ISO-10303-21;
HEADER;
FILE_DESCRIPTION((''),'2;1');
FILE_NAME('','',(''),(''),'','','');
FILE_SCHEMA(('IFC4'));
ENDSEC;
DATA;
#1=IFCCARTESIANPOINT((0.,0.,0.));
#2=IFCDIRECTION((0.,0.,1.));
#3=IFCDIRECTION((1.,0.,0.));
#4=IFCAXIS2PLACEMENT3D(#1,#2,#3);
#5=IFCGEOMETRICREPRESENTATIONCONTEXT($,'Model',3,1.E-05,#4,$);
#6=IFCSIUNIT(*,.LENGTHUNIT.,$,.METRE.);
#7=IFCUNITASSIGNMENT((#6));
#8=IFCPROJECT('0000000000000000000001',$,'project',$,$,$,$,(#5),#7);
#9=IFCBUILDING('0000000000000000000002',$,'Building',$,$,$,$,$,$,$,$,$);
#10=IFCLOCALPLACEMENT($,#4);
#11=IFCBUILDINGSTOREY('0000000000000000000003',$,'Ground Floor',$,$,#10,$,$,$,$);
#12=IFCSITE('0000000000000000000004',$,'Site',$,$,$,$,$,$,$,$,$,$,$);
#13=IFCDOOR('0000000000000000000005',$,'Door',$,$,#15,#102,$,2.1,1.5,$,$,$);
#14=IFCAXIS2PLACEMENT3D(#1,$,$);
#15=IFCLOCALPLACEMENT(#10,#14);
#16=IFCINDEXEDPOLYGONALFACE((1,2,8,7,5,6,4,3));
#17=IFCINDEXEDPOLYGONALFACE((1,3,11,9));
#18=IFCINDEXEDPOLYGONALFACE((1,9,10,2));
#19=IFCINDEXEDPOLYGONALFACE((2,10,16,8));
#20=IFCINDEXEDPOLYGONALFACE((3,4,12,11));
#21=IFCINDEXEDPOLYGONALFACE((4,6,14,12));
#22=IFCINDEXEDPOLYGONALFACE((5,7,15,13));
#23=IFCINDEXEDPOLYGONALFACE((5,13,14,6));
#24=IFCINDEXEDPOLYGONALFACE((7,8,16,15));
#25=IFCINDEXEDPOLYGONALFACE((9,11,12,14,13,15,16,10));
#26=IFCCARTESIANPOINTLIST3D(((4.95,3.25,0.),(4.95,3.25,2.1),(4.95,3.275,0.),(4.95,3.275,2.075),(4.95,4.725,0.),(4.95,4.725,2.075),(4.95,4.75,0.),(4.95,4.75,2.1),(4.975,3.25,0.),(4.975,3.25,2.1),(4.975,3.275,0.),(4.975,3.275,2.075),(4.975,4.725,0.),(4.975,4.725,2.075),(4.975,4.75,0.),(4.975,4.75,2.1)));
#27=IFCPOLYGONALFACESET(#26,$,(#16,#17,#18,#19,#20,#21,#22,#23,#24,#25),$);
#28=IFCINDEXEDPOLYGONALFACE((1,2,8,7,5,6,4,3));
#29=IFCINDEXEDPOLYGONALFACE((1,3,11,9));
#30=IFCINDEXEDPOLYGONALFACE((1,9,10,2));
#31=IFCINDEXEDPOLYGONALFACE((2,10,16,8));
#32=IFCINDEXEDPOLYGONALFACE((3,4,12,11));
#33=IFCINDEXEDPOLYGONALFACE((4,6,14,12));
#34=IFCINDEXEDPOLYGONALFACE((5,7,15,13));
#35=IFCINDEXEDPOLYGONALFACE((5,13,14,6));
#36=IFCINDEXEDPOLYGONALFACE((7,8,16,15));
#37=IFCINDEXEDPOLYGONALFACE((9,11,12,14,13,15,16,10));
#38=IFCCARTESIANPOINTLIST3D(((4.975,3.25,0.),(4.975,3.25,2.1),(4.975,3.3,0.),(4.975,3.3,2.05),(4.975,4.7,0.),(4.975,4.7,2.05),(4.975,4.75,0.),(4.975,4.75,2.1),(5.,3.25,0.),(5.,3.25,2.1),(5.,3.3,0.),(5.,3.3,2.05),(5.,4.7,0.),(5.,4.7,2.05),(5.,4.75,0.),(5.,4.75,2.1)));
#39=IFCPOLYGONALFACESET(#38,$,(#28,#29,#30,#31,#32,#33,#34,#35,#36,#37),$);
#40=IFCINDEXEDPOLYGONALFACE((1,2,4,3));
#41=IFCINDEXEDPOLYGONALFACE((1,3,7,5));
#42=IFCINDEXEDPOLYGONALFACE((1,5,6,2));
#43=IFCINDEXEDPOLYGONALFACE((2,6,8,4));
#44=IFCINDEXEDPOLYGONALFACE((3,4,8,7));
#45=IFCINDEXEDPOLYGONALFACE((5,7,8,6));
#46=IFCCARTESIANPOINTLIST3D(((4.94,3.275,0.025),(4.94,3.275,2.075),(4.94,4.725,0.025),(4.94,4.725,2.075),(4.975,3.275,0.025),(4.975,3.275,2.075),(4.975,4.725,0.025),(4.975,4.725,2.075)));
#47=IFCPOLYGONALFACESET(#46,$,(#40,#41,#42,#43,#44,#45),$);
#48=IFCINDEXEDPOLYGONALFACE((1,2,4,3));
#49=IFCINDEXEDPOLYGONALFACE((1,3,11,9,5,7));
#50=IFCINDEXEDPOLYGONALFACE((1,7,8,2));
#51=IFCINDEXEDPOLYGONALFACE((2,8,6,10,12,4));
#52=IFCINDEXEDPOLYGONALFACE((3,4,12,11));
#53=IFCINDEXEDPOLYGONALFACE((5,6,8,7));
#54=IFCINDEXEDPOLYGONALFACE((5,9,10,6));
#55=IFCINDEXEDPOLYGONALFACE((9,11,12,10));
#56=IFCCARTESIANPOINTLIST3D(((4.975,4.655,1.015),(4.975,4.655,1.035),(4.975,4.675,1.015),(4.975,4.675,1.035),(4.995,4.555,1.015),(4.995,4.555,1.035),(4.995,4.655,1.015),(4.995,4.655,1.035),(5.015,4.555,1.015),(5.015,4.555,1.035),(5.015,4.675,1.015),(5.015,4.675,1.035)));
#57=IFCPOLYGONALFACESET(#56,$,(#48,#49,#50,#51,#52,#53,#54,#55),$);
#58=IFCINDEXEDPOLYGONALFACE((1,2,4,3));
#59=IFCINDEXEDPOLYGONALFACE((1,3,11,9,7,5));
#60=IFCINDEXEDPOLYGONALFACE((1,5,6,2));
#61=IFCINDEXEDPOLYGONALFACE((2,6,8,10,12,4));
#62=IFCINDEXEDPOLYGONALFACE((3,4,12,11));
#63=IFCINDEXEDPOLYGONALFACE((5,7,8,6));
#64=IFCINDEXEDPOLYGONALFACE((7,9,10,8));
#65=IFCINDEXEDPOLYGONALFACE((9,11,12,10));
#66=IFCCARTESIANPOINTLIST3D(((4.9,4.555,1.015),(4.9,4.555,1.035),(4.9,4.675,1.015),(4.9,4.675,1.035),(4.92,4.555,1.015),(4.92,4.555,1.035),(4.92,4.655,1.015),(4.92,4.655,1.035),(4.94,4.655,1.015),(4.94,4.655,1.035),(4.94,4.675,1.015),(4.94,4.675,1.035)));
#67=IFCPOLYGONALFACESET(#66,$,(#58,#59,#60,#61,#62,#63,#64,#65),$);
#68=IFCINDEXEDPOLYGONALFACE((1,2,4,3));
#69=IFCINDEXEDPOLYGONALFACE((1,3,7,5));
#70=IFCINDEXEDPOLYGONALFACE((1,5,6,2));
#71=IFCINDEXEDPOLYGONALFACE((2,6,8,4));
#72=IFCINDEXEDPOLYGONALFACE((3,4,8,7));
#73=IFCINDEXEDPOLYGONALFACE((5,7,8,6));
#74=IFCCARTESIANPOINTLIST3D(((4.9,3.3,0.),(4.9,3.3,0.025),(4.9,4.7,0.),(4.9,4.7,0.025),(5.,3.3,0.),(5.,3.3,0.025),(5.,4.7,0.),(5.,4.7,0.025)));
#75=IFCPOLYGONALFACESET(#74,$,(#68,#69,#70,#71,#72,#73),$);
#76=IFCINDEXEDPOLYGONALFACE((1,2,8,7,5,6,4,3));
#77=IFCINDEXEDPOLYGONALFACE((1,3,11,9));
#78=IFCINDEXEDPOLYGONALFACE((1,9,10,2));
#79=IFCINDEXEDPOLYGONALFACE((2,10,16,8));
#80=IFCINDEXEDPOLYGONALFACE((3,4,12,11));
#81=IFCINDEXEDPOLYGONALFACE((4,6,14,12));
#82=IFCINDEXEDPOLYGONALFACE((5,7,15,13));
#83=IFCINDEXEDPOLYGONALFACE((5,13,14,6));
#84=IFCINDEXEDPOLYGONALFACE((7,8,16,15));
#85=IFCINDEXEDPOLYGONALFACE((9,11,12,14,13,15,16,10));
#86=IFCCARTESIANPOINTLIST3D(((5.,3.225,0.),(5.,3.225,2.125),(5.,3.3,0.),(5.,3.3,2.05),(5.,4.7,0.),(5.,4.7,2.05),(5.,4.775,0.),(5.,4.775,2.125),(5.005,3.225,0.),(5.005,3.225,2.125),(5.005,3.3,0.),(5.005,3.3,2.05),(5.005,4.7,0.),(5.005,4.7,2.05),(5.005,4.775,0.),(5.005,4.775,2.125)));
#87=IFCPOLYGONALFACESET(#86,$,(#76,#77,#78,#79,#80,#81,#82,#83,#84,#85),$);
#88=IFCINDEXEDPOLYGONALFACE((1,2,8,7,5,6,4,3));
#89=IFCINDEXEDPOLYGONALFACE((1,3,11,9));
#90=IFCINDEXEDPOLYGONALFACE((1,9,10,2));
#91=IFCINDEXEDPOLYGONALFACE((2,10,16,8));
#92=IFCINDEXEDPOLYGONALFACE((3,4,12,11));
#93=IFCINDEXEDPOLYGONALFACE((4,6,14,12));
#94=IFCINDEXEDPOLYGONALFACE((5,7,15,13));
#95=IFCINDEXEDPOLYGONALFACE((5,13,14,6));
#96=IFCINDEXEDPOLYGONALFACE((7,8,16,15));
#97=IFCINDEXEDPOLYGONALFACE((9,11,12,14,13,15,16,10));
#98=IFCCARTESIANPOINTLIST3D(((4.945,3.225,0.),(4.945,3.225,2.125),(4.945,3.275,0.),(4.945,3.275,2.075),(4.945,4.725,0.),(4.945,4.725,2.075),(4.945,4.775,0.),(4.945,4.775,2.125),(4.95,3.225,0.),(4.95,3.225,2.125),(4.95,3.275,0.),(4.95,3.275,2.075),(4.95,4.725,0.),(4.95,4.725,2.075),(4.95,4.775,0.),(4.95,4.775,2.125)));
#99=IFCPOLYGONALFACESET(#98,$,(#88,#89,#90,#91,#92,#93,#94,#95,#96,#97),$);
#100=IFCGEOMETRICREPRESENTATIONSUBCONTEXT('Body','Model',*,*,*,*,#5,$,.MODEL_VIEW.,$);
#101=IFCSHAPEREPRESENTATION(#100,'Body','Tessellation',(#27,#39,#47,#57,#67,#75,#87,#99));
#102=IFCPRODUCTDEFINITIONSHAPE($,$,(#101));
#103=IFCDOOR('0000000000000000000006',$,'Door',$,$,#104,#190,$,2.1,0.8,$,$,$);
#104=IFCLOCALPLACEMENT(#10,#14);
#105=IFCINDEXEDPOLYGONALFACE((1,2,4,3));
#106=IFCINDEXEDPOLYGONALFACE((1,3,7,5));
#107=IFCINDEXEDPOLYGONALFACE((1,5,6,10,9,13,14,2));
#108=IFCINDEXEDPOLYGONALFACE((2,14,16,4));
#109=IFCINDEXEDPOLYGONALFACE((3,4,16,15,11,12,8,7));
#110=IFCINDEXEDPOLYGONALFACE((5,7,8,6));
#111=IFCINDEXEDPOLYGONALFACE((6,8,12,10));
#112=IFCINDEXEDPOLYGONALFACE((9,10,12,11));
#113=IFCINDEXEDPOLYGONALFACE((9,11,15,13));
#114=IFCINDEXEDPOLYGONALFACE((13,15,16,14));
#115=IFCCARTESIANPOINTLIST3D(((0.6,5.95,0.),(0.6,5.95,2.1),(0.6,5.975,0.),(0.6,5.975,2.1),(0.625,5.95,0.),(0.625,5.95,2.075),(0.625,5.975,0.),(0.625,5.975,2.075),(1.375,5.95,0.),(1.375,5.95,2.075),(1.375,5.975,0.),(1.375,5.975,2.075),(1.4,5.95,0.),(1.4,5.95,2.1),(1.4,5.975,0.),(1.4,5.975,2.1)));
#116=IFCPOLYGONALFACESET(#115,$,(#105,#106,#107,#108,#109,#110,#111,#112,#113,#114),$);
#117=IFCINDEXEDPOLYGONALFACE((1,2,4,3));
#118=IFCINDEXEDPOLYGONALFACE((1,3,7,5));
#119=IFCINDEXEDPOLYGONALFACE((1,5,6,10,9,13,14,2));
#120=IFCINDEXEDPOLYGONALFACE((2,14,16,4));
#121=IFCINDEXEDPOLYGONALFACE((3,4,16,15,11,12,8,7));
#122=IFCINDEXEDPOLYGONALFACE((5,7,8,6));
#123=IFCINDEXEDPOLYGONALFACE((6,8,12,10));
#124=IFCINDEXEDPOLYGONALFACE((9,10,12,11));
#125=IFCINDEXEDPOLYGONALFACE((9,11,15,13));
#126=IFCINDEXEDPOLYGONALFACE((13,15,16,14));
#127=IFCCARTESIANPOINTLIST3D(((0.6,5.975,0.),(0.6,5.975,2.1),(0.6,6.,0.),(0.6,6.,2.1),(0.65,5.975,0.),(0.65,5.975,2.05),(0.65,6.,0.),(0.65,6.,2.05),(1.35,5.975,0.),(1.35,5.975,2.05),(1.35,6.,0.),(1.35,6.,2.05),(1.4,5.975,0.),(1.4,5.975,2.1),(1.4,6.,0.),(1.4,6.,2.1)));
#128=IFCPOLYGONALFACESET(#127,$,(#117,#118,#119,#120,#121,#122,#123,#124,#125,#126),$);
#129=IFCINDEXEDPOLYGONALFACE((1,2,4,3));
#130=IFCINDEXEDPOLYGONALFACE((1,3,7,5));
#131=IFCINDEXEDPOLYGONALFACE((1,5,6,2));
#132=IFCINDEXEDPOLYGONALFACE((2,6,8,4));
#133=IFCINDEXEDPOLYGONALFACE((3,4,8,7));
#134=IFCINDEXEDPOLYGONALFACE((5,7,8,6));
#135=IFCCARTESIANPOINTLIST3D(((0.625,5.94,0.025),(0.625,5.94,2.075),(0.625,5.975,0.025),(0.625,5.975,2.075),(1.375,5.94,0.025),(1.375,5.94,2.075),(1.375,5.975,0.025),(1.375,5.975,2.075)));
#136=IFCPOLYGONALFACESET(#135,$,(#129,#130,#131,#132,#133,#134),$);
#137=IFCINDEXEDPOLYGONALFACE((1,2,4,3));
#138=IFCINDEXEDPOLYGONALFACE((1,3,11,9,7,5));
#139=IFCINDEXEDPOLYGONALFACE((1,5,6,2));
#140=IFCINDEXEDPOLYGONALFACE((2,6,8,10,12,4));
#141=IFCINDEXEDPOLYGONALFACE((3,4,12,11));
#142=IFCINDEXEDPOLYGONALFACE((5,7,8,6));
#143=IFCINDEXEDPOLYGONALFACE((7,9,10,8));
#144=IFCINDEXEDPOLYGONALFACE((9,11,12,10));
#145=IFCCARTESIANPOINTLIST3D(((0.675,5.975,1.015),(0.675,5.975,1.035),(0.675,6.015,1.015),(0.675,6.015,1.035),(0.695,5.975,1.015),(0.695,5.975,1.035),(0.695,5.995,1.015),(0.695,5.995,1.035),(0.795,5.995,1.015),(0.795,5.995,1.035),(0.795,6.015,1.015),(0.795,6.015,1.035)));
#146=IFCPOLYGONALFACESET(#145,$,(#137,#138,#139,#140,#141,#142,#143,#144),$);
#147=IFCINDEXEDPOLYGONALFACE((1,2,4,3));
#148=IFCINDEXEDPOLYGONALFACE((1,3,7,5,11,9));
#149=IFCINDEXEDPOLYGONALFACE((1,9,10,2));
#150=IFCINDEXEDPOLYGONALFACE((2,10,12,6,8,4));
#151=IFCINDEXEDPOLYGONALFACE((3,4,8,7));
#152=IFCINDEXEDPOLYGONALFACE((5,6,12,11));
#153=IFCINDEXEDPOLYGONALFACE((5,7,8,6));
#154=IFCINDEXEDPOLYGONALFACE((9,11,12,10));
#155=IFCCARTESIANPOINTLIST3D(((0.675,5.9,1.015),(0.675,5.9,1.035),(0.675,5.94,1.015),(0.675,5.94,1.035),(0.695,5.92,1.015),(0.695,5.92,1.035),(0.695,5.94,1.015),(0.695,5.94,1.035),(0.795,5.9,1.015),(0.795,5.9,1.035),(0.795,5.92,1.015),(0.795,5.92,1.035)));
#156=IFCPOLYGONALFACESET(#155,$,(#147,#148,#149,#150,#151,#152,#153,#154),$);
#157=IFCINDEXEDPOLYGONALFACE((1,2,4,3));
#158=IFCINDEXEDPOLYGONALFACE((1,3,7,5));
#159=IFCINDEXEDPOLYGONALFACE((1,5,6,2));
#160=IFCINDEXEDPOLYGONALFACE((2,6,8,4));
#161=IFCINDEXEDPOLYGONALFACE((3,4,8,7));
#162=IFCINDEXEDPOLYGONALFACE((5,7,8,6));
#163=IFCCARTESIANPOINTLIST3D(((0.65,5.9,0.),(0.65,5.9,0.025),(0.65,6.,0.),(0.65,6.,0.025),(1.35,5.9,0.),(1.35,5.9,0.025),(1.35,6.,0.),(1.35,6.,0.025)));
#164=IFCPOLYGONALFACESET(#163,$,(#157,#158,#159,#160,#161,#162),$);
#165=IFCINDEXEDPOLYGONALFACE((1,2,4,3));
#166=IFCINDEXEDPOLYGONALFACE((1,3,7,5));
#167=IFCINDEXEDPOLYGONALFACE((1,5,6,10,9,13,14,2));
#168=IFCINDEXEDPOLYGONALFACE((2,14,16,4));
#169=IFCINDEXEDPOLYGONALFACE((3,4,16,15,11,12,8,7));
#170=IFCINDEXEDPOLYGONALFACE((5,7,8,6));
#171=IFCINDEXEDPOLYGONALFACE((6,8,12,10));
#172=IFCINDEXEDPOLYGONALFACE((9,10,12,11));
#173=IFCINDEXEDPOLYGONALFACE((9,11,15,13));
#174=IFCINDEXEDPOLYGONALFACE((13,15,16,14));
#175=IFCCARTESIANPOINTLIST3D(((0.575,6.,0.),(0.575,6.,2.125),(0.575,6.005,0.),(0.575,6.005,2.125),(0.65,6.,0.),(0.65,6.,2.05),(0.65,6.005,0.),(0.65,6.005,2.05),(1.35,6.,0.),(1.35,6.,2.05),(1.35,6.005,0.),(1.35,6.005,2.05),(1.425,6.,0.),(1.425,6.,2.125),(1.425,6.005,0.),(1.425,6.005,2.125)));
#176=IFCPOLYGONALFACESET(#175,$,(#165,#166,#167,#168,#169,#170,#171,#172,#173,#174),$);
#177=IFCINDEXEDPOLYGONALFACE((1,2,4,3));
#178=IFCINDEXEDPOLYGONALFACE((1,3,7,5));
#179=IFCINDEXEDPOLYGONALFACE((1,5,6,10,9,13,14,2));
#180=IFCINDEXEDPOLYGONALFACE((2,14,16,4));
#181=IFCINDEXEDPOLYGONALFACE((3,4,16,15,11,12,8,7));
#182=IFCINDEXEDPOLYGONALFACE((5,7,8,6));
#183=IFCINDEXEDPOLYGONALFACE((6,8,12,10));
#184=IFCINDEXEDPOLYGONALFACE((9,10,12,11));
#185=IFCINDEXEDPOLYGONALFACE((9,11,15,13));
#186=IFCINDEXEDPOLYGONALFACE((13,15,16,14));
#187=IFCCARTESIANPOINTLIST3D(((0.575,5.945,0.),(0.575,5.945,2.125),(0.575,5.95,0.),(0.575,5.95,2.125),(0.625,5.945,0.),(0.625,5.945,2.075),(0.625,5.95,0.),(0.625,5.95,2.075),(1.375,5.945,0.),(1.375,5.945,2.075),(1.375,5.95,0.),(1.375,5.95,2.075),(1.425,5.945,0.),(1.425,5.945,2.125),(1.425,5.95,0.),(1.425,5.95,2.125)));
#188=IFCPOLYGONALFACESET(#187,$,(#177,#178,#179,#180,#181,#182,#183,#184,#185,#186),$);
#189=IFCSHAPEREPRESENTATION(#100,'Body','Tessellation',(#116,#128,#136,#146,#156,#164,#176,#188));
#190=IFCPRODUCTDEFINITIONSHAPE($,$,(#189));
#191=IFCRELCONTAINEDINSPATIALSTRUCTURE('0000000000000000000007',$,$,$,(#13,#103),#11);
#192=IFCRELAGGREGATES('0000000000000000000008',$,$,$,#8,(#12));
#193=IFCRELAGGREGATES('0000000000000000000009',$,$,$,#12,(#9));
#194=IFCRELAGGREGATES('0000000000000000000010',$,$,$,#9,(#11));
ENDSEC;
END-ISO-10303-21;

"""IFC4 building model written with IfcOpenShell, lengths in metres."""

from ifc_helpers import new_model, si_unit, frame, origin_with_axes, place, context, subcontext, project, spatial, line, indexed_curve, outline, extrude, element, save


model = new_model("IFC4")

# Units and contexts
model_context = context("Model", 3, precision=1e-05, world=origin_with_axes())
body_context = subcontext(model_context, "Body", "Model", "MODEL_VIEW")
ifc_project = project(units=[si_unit("LENGTHUNIT", "METRE")], contexts=[model_context])

# Site, building, storey
site = spatial("IfcSite", under=ifc_project, Name="Site")
building = spatial("IfcBuilding", under=site, Name="Building")
storey_placement = place(None, origin_with_axes())
storey = spatial("IfcBuildingStorey", under=building, at=storey_placement, Name="Ground Floor")

# Doors
door_1_placement = place(storey_placement, frame((5.0, 3.25, 0.0), z_axis=(0.0, 0.0, 1.0), x_axis=(0.0, 1.0, 0.0)))
element("IfcDoor", 1, at=door_1_placement, inside=storey, Name="Door", OverallHeight=2.1, OverallWidth=1.5, context=body_context, shape_type="SweptSolid", body=[
    extrude(outline(indexed_curve([(0.0, 0.0), (0.0, 2.1), (1.5, 2.1), (1.5, 0.0), (1.475, 0.0), (1.475, 2.075), (0.025, 2.075), (0.025, 0.0)], segments=[line(1, 2, 3, 4, 5, 6, 7, 8, 1)])), frame((0.0, 0.025, 0.0), z_axis=(0.0, -1.0, 0.0), x_axis=(1.0, 0.0, 0.0)), (0.0, 0.0, -1.0), 0.025),
    extrude(outline(indexed_curve([(0.0, 0.0), (0.0, 2.1), (1.5, 2.1), (1.5, 0.0), (1.45, 0.0), (1.45, 2.05), (0.05, 2.05), (0.05, 0.0)], segments=[line(1, 2, 3, 4, 5, 6, 7, 8, 1)])), frame((0.0, 0.0, 0.0), z_axis=(0.0, -1.0, 0.0), x_axis=(1.0, 0.0, 0.0)), (0.0, 0.0, -1.0), 0.025),
    extrude(outline(indexed_curve([(0.0, 0.0), (1.45, 0.0), (1.45, 0.035), (0.0, 0.035)], segments=[line(1, 2, 3, 4, 1)])), frame((0.025, 0.025, 0.025), z_axis=(0.0, 0.0, 1.0), x_axis=(1.0, 0.0, 0.0)), (0.0, 0.0, 1.0), 2.05),
    extrude(outline(indexed_curve([(0.0, 0.0), (0.0, -0.04), (-0.12, -0.04), (-0.12, -0.02), (-0.02, -0.02), (-0.02, 0.0)], segments=[line(1, 2, 3, 4, 5, 6, 1)])), frame((1.425, 0.025, 1.015), z_axis=(0.0, 0.0, 1.0), x_axis=(1.0, 0.0, 0.0)), (0.0, 0.0, 1.0), 0.02),
    extrude(outline(indexed_curve([(0.0, 0.0), (0.0, 0.04), (-0.12, 0.04), (-0.12, 0.02), (-0.02, 0.02), (-0.02, 0.0)], segments=[line(1, 2, 3, 4, 5, 6, 1)])), frame((1.425, 0.06, 1.015), z_axis=(0.0, 0.0, 1.0), x_axis=(1.0, 0.0, 0.0)), (0.0, 0.0, 1.0), 0.02),
    extrude(outline(indexed_curve([(0.0, 0.0), (1.4, 0.0), (1.4, 0.1), (0.0, 0.1)], segments=[line(1, 2, 3, 4, 1)])), frame((0.05, 0.0, 0.0), z_axis=(0.0, 0.0, 1.0), x_axis=(1.0, 0.0, 0.0)), (0.0, 0.0, 1.0), 0.025),
    extrude(outline(indexed_curve([(0.0, 0.0), (0.0, 2.125), (1.55, 2.125), (1.55, 0.0), (1.475, 0.0), (1.475, 2.05), (0.075, 2.05), (0.075, 0.0)], segments=[line(1, 2, 3, 4, 5, 6, 7, 8, 1)])), frame((-0.025, -0.005, 0.0), z_axis=(0.0, -1.0, 0.0), x_axis=(1.0, 0.0, 0.0)), (0.0, 0.0, -1.0), 0.005),
    extrude(outline(indexed_curve([(0.0, 0.0), (0.0, 2.125), (1.55, 2.125), (1.55, 0.0), (1.5, 0.0), (1.5, 2.075), (0.05, 2.075), (0.05, 0.0)], segments=[line(1, 2, 3, 4, 5, 6, 7, 8, 1)])), frame((-0.025, 0.05, 0.0), z_axis=(0.0, -1.0, 0.0), x_axis=(1.0, 0.0, 0.0)), (0.0, 0.0, -1.0), 0.005),
])
door_2_placement = place(storey_placement, frame((1.4, 6.0, 0.0), z_axis=(0.0, 0.0, 1.0), x_axis=(-1.0, 0.0, 0.0)))
element("IfcDoor", 2, at=door_2_placement, inside=storey, Name="Door", OverallHeight=2.1, OverallWidth=0.8, context=body_context, shape_type="SweptSolid", body=[
    extrude(outline(indexed_curve([(0.0, 0.0), (0.0, 2.1), (0.8, 2.1), (0.8, 0.0), (0.775, 0.0), (0.775, 2.075), (0.025, 2.075), (0.025, 0.0)], segments=[line(1, 2, 3, 4, 5, 6, 7, 8, 1)])), frame((0.0, 0.025, 0.0), z_axis=(0.0, -1.0, 0.0), x_axis=(1.0, 0.0, 0.0)), (0.0, 0.0, -1.0), 0.025),
    extrude(outline(indexed_curve([(0.0, 0.0), (0.0, 2.1), (0.8, 2.1), (0.8, 0.0), (0.75, 0.0), (0.75, 2.05), (0.05, 2.05), (0.05, 0.0)], segments=[line(1, 2, 3, 4, 5, 6, 7, 8, 1)])), frame((0.0, 0.0, 0.0), z_axis=(0.0, -1.0, 0.0), x_axis=(1.0, 0.0, 0.0)), (0.0, 0.0, -1.0), 0.025),
    extrude(outline(indexed_curve([(0.0, 0.0), (0.75, 0.0), (0.75, 0.035), (0.0, 0.035)], segments=[line(1, 2, 3, 4, 1)])), frame((0.025, 0.025, 0.025), z_axis=(0.0, 0.0, 1.0), x_axis=(1.0, 0.0, 0.0)), (0.0, 0.0, 1.0), 2.05),
    extrude(outline(indexed_curve([(0.0, 0.0), (0.0, -0.04), (-0.12, -0.04), (-0.12, -0.02), (-0.02, -0.02), (-0.02, 0.0)], segments=[line(1, 2, 3, 4, 5, 6, 1)])), frame((0.725, 0.025, 1.015), z_axis=(0.0, 0.0, 1.0), x_axis=(1.0, 0.0, 0.0)), (0.0, 0.0, 1.0), 0.02),
    extrude(outline(indexed_curve([(0.0, 0.0), (0.0, 0.04), (-0.12, 0.04), (-0.12, 0.02), (-0.02, 0.02), (-0.02, 0.0)], segments=[line(1, 2, 3, 4, 5, 6, 1)])), frame((0.725, 0.06, 1.015), z_axis=(0.0, 0.0, 1.0), x_axis=(1.0, 0.0, 0.0)), (0.0, 0.0, 1.0), 0.02),
    extrude(outline(indexed_curve([(0.0, 0.0), (0.7, 0.0), (0.7, 0.1), (0.0, 0.1)], segments=[line(1, 2, 3, 4, 1)])), frame((0.05, 0.0, 0.0), z_axis=(0.0, 0.0, 1.0), x_axis=(1.0, 0.0, 0.0)), (0.0, 0.0, 1.0), 0.025),
    extrude(outline(indexed_curve([(0.0, 0.0), (0.0, 2.125), (0.85, 2.125), (0.85, 0.0), (0.775, 0.0), (0.775, 2.05), (0.075, 2.05), (0.075, 0.0)], segments=[line(1, 2, 3, 4, 5, 6, 7, 8, 1)])), frame((-0.025, -0.005, 0.0), z_axis=(0.0, -1.0, 0.0), x_axis=(1.0, 0.0, 0.0)), (0.0, 0.0, -1.0), 0.005),
    extrude(outline(indexed_curve([(0.0, 0.0), (0.0, 2.125), (0.85, 2.125), (0.85, 0.0), (0.8, 0.0), (0.8, 2.075), (0.05, 2.075), (0.05, 0.0)], segments=[line(1, 2, 3, 4, 5, 6, 7, 8, 1)])), frame((-0.025, 0.05, 0.0), z_axis=(0.0, -1.0, 0.0), x_axis=(1.0, 0.0, 0.0)), (0.0, 0.0, -1.0), 0.005),
])

save(model, "model.ifc")
